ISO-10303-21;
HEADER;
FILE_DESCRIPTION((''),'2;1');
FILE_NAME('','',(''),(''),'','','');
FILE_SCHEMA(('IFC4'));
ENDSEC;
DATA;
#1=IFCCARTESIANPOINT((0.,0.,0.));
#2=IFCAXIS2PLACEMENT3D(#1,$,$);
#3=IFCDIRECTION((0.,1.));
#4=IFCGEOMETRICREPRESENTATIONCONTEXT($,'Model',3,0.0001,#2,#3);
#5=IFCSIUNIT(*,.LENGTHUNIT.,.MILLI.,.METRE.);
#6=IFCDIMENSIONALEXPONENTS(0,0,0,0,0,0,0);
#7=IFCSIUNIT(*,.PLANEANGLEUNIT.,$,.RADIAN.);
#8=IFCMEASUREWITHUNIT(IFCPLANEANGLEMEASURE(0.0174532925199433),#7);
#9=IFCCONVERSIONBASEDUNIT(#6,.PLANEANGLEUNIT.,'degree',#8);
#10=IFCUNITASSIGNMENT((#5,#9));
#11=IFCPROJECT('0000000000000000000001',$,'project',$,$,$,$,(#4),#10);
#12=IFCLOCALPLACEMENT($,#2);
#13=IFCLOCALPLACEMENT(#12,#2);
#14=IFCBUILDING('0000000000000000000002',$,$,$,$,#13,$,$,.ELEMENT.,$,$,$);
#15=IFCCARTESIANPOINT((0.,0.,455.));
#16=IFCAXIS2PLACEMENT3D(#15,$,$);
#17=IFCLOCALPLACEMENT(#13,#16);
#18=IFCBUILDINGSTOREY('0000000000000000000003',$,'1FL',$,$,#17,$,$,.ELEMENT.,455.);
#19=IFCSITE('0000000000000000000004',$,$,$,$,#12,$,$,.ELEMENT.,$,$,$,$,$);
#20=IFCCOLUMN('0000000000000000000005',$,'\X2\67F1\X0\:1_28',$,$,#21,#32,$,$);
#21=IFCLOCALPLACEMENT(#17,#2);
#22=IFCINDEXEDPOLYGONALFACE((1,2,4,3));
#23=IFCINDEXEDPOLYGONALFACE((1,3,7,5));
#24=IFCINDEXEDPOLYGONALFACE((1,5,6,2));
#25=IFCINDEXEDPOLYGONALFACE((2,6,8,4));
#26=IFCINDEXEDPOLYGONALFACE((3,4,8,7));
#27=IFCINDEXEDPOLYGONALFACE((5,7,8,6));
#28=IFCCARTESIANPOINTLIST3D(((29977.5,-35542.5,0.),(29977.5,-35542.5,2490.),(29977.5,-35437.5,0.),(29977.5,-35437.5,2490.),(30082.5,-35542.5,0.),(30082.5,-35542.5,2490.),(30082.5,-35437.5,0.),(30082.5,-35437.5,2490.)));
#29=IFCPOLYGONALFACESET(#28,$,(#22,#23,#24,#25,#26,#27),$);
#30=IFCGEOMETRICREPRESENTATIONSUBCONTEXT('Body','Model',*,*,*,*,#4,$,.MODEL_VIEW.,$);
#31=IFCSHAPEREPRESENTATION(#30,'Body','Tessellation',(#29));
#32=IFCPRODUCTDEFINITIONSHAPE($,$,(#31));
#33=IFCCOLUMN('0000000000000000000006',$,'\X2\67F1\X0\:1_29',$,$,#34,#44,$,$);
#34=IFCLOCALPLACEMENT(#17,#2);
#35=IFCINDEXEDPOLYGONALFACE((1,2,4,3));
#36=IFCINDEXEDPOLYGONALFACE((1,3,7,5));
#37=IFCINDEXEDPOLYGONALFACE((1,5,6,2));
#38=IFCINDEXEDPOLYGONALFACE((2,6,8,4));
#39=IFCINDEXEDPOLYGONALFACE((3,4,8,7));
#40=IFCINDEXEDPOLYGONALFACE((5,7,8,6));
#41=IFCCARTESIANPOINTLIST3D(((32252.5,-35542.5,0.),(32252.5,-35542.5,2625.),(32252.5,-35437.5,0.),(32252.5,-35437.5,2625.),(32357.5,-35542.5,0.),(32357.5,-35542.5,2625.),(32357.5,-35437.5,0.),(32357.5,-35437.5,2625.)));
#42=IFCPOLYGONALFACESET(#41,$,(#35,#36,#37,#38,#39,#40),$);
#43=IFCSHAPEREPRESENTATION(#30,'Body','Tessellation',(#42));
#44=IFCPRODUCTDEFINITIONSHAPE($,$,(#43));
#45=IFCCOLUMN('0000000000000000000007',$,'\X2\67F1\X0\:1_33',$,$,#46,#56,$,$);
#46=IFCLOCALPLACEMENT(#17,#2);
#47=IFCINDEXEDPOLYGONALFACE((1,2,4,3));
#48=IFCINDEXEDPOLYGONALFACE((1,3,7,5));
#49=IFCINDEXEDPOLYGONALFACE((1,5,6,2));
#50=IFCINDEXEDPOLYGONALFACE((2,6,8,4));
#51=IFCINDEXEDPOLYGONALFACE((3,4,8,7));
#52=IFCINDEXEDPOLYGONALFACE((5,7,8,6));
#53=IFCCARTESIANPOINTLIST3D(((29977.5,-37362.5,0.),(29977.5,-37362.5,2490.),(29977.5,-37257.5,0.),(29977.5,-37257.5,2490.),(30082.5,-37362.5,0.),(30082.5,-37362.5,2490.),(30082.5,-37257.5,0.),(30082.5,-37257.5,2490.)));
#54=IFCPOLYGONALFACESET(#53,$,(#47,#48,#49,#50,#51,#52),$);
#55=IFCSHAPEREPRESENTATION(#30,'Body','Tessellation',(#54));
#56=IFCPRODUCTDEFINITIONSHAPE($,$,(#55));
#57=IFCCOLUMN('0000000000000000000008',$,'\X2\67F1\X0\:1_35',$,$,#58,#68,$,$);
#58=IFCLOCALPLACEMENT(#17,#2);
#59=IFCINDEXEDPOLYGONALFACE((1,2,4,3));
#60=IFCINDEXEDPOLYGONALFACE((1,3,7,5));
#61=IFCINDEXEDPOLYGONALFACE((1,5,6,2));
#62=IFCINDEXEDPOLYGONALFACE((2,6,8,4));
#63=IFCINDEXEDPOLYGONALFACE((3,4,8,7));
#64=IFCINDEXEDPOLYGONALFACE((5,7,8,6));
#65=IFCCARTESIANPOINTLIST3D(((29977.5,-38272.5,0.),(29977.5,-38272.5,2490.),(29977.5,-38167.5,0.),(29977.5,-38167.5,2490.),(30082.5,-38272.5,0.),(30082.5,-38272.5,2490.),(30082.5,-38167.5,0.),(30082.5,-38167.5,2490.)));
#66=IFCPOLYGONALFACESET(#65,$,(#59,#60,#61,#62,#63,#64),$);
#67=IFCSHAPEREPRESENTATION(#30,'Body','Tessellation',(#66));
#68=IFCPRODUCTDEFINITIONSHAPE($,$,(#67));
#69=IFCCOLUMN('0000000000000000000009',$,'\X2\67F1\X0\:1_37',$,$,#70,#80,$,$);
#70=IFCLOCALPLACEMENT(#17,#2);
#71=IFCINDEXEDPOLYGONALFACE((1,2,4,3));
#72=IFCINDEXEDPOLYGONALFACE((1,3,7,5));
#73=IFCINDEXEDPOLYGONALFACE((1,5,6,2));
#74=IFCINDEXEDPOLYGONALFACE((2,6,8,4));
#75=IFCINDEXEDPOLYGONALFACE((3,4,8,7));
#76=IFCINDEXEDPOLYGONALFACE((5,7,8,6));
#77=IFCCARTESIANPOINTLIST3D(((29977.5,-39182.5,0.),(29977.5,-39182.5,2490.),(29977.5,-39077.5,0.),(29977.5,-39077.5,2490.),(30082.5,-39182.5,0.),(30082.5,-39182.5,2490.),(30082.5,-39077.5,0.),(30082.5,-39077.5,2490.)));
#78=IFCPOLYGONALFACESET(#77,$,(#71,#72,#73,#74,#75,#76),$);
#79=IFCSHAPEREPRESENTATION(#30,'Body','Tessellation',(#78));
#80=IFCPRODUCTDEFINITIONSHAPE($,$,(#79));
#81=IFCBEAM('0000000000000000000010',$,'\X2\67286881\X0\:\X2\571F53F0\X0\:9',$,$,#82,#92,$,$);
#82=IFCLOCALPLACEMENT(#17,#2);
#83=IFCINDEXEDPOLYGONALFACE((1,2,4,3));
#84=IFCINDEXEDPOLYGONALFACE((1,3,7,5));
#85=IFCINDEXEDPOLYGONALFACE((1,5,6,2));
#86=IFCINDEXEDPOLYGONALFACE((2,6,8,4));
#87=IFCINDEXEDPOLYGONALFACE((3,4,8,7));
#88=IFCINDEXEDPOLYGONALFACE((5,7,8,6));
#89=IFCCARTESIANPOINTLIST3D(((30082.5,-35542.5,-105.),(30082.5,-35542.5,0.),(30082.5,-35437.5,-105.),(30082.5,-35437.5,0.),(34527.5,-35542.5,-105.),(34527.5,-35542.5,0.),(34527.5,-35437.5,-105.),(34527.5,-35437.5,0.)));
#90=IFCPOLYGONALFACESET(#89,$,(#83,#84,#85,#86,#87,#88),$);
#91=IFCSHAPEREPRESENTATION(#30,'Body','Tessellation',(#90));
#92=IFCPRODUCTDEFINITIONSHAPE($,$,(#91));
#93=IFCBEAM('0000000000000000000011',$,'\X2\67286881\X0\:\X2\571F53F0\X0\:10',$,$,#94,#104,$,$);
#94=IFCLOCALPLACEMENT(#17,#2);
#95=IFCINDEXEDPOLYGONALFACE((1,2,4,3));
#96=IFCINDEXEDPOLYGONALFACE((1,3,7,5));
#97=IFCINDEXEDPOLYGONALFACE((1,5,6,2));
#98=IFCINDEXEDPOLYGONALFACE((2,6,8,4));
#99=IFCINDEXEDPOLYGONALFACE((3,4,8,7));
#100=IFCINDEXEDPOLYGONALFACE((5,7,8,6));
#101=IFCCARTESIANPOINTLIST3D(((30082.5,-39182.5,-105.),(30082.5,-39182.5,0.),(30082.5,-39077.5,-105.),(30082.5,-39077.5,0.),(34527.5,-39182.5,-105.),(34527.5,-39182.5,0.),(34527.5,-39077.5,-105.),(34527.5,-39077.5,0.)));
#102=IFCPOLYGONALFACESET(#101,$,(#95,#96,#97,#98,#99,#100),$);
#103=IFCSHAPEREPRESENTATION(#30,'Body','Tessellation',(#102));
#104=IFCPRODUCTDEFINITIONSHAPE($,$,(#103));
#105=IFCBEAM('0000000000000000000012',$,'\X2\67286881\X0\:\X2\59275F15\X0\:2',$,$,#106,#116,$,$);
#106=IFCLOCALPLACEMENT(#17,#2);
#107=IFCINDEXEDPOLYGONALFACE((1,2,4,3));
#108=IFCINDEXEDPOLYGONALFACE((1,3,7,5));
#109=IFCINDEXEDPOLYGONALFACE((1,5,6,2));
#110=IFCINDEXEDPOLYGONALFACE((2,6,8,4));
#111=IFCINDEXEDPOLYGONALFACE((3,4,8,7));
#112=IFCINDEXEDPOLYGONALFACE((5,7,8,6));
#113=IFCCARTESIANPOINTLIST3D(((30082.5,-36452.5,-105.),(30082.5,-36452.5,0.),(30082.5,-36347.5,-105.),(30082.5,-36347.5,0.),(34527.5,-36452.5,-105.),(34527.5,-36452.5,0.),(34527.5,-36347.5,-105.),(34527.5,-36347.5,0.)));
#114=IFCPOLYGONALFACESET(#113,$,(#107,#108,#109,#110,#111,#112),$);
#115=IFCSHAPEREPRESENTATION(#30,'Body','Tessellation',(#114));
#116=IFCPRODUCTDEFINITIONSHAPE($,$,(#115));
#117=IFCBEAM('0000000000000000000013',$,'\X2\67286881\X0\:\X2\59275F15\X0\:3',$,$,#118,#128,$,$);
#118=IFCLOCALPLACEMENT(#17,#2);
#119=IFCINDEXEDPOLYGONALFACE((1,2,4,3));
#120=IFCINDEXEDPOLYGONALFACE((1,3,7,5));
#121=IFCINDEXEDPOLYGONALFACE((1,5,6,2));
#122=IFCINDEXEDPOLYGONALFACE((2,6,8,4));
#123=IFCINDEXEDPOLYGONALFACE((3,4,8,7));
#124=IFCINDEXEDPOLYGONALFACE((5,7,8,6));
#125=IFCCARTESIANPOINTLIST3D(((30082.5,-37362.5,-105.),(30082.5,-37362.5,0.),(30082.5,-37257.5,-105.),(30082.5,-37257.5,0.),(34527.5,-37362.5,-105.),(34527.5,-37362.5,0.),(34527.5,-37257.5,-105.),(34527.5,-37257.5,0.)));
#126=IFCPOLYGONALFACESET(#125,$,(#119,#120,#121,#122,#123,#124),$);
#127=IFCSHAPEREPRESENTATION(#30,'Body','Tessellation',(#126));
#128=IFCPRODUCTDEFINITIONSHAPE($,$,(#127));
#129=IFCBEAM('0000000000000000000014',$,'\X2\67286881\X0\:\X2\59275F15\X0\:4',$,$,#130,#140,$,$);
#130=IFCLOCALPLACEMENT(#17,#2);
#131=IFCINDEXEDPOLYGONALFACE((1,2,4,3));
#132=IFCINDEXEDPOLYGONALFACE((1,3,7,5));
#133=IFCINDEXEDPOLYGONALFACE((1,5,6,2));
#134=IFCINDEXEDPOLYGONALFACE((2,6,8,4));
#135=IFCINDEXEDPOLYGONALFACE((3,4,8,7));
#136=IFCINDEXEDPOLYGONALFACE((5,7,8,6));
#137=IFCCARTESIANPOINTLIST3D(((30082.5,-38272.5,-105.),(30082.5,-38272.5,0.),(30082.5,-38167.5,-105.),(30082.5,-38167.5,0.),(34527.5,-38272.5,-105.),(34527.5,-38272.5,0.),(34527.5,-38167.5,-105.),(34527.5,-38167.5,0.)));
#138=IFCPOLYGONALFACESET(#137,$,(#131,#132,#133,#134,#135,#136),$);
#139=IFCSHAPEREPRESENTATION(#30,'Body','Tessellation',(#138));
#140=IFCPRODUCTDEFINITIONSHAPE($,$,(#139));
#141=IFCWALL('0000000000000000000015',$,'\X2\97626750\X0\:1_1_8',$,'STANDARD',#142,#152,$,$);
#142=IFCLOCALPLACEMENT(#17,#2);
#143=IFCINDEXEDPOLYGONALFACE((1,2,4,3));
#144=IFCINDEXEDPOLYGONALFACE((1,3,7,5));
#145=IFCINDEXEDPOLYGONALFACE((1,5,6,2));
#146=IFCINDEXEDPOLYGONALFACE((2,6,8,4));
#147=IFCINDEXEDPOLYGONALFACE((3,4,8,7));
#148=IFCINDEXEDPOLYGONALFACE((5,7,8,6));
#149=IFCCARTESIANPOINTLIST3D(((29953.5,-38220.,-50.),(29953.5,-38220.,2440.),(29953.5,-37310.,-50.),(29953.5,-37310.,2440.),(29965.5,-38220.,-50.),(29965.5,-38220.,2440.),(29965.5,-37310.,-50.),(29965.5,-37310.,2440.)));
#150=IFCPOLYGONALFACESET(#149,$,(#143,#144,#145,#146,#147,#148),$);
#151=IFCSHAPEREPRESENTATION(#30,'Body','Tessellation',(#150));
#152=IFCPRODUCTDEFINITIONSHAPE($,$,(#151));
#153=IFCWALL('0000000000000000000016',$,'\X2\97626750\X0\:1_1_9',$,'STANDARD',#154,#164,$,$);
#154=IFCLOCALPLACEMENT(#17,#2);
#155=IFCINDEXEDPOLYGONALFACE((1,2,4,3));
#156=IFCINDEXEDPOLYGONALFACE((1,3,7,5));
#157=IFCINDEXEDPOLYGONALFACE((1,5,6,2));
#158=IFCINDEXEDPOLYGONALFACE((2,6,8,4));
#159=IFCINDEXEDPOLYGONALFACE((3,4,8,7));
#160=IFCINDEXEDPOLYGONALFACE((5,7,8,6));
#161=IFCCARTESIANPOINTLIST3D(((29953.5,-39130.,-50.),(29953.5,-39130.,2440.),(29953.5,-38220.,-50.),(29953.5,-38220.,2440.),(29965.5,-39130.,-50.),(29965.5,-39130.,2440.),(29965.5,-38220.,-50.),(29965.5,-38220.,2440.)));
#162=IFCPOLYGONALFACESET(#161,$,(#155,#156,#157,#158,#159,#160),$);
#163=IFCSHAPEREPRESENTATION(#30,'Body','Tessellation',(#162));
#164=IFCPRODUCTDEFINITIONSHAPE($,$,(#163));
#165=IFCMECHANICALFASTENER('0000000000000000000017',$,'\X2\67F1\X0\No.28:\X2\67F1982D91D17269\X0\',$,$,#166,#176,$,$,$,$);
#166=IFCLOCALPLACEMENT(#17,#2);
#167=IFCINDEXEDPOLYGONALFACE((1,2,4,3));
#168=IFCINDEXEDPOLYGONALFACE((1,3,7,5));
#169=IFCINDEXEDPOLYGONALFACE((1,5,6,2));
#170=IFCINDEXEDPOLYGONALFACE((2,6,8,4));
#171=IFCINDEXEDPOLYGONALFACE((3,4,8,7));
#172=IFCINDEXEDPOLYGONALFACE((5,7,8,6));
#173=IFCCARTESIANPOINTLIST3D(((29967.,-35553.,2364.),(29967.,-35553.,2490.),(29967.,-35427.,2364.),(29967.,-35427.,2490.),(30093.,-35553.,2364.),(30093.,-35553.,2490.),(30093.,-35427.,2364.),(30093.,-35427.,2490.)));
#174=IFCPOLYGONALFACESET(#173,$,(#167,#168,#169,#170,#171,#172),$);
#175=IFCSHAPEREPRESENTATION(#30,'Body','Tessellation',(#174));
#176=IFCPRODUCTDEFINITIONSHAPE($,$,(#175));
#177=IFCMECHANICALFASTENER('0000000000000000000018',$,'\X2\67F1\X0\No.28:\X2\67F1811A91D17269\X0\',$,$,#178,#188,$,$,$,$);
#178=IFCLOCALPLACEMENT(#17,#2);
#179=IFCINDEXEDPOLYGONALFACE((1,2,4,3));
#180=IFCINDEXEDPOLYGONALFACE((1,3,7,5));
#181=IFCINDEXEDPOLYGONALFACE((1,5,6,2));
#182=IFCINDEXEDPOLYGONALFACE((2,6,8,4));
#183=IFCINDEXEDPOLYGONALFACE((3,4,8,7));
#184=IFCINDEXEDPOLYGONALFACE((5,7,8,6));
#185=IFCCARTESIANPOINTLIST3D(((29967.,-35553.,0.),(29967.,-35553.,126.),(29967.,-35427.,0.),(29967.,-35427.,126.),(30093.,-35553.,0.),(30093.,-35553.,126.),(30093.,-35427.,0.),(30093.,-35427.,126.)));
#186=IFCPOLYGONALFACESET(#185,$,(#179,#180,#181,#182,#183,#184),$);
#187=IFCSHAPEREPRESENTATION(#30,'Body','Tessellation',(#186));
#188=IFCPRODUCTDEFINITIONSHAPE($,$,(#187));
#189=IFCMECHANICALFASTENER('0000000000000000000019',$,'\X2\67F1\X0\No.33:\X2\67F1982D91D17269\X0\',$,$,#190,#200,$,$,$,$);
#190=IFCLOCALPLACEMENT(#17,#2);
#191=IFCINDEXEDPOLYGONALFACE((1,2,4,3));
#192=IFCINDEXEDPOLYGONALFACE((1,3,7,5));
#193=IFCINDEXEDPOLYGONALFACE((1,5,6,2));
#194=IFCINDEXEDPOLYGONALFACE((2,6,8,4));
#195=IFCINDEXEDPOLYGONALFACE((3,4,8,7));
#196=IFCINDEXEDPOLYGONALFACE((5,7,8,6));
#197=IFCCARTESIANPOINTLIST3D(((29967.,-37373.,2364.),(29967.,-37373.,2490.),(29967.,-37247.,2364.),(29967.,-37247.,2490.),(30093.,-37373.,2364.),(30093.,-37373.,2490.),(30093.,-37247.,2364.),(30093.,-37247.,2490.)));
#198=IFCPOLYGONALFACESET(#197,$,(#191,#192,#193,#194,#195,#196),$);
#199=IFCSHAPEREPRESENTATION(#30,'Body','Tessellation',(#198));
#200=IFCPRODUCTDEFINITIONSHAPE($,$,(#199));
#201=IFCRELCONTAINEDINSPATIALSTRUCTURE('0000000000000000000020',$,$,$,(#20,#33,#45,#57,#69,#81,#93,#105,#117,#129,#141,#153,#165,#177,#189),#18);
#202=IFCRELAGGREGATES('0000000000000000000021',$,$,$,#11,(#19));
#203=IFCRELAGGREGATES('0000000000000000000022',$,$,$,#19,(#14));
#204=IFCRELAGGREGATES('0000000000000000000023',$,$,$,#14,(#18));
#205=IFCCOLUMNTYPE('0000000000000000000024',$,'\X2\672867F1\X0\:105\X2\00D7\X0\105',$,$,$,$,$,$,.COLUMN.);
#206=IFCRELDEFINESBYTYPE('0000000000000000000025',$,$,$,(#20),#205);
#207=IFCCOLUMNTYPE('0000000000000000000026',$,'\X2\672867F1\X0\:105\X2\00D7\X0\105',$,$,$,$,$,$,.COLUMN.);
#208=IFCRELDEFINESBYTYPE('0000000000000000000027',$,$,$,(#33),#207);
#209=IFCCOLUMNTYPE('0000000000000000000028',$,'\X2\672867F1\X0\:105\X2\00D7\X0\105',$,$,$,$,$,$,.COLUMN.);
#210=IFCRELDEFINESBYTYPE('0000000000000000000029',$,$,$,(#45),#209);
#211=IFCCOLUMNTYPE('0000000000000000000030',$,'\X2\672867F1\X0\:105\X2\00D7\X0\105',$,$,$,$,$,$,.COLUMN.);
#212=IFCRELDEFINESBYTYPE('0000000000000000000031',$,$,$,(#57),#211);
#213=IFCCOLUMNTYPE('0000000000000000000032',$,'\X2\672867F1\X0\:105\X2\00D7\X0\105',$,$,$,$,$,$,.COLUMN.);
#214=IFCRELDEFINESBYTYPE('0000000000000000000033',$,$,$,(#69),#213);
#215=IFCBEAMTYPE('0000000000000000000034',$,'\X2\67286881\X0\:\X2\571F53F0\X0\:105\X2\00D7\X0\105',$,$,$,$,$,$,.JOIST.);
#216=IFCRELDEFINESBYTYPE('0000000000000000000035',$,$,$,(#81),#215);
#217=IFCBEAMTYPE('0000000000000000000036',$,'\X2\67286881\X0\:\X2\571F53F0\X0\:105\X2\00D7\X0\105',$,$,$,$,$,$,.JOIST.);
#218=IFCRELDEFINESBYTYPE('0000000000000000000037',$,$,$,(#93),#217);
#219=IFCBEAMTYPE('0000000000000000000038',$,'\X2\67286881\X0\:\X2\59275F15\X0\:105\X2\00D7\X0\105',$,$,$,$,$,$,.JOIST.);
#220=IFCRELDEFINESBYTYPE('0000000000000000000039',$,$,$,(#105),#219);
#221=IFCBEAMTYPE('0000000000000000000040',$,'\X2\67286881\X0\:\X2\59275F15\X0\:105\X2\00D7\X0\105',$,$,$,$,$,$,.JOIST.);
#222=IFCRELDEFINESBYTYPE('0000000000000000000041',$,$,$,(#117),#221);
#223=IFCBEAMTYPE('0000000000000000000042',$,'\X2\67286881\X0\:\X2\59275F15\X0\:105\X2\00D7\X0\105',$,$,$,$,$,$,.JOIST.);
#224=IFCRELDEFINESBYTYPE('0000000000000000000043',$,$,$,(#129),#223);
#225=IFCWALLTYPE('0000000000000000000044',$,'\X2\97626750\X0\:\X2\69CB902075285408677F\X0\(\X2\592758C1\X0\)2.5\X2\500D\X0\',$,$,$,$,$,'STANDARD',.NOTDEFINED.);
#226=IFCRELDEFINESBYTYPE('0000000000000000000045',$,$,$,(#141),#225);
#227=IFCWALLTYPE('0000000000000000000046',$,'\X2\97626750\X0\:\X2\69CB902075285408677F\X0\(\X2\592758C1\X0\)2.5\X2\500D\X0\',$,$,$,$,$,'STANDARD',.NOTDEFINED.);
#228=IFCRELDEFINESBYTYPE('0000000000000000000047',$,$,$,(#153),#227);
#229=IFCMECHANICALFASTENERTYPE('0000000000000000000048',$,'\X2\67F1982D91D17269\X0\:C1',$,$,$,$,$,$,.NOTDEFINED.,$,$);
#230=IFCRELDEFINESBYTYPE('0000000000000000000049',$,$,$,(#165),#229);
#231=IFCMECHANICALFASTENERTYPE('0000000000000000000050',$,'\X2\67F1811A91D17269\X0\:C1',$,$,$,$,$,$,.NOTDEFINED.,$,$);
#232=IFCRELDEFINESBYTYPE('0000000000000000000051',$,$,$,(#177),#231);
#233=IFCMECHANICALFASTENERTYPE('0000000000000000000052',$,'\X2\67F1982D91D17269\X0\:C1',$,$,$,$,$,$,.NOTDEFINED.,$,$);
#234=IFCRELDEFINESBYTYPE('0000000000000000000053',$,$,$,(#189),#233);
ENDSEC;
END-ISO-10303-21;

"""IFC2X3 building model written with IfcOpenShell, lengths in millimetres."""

from ifc_helpers import new_model, entity, si_unit, converted_unit, direction, frame, origin, origin_with_axes, origin_2d, place, context, subcontext, project, spatial, polyline, rectangle, outline, extrude, type_object, element, save


model = new_model("IFC2X3")

# Units and contexts
model_context = context("Model", 3, precision=0.0001, world=origin(), true_north=direction((0.0, 1.0)))
body_context = subcontext(model_context, "Body", "Model", "MODEL_VIEW")
ifc_project = project(units=[si_unit("LENGTHUNIT", "METRE", prefix="MILLI"), converted_unit("PLANEANGLEUNIT", "degree", entity("IfcPlaneAngleMeasure", 0.0174532925199433), si_unit("PLANEANGLEUNIT", "RADIAN"), dimensions=[0, 0, 0, 0, 0, 0, 0])], contexts=[model_context])

# Site, building, storey
site_placement = place(None, origin())
site = spatial("IfcSite", under=ifc_project, at=site_placement, CompositionType="ELEMENT")
building_placement = place(site_placement, origin())
building = spatial("IfcBuilding", under=site, at=building_placement, CompositionType="ELEMENT")
storey_placement = place(building_placement, frame((0.0, 0.0, 455.0)))
storey = spatial("IfcBuildingStorey", under=building, at=storey_placement, Name="1FL", CompositionType="ELEMENT", Elevation=455.0)

# Columns
column_type_1 = type_object("IfcColumnType", Name="木柱:105×105", PredefinedType="COLUMN")
column_1_placement = place(storey_placement, frame((30030.0, -35490.0, 0.0)))
element("IfcColumn", 1, at=column_1_placement, inside=storey, type_object=column_type_1, Name="柱:1_28", context=body_context, shape_type="SweptSolid", body=[
    extrude(rectangle(XDim=105.0, YDim=105.0, at=origin_2d()), origin_with_axes(), (0.0, 0.0, 1.0), 2490.0),
])
column_type_2 = type_object("IfcColumnType", Name="木柱:105×105", PredefinedType="COLUMN")
column_2_placement = place(storey_placement, frame((32305.0, -35490.0, 0.0)))
element("IfcColumn", 2, at=column_2_placement, inside=storey, type_object=column_type_2, Name="柱:1_29", context=body_context, shape_type="SweptSolid", body=[
    extrude(rectangle(XDim=105.0, YDim=105.0, at=origin_2d()), origin_with_axes(), (0.0, 0.0, 1.0), 2625.0),
])
column_type_3 = type_object("IfcColumnType", Name="木柱:105×105", PredefinedType="COLUMN")
column_3_placement = place(storey_placement, frame((30030.0, -37310.0, 0.0)))
element("IfcColumn", 3, at=column_3_placement, inside=storey, type_object=column_type_3, Name="柱:1_33", context=body_context, shape_type="SweptSolid", body=[
    extrude(rectangle(XDim=105.0, YDim=105.0, at=origin_2d()), origin_with_axes(), (0.0, 0.0, 1.0), 2490.0),
])
column_type_4 = type_object("IfcColumnType", Name="木柱:105×105", PredefinedType="COLUMN")
column_4_placement = place(storey_placement, frame((30030.0, -38220.0, 0.0)))
element("IfcColumn", 4, at=column_4_placement, inside=storey, type_object=column_type_4, Name="柱:1_35", context=body_context, shape_type="SweptSolid", body=[
    extrude(rectangle(XDim=105.0, YDim=105.0, at=origin_2d()), origin_with_axes(), (0.0, 0.0, 1.0), 2490.0),
])
column_type_5 = type_object("IfcColumnType", Name="木柱:105×105", PredefinedType="COLUMN")
column_5_placement = place(storey_placement, frame((30030.0, -39130.0, 0.0)))
element("IfcColumn", 5, at=column_5_placement, inside=storey, type_object=column_type_5, Name="柱:1_37", context=body_context, shape_type="SweptSolid", body=[
    extrude(rectangle(XDim=105.0, YDim=105.0, at=origin_2d()), origin_with_axes(), (0.0, 0.0, 1.0), 2490.0),
])

# Beams
beam_type_1 = type_object("IfcBeamType", Name="木梁:土台:105×105", PredefinedType="JOIST")
beam_1_placement = place(storey_placement, frame((30082.5, -35490.0, -52.5), z_axis=(1.0, 0.0, 0.0), x_axis=(0.0, 1.0, 0.0)))
element("IfcBeam", 6, at=beam_1_placement, inside=storey, type_object=beam_type_1, Name="木梁:土台:9", context=body_context, shape_type="SweptSolid", body=[
    extrude(rectangle(XDim=105.0, YDim=105.0, at=origin_2d()), origin_with_axes(), (0.0, 0.0, 1.0), 4445.0),
])
beam_type_2 = type_object("IfcBeamType", Name="木梁:土台:105×105", PredefinedType="JOIST")
beam_2_placement = place(storey_placement, frame((30082.5, -39130.0, -52.5), z_axis=(1.0, 0.0, 0.0), x_axis=(0.0, 1.0, 0.0)))
element("IfcBeam", 7, at=beam_2_placement, inside=storey, type_object=beam_type_2, Name="木梁:土台:10", context=body_context, shape_type="SweptSolid", body=[
    extrude(rectangle(XDim=105.0, YDim=105.0, at=origin_2d()), origin_with_axes(), (0.0, 0.0, 1.0), 4445.0),
])
beam_type_3 = type_object("IfcBeamType", Name="木梁:大引:105×105", PredefinedType="JOIST")
beam_3_placement = place(storey_placement, frame((30082.5, -36400.0, -52.5), z_axis=(1.0, 0.0, 0.0), x_axis=(0.0, 1.0, 0.0)))
element("IfcBeam", 8, at=beam_3_placement, inside=storey, type_object=beam_type_3, Name="木梁:大引:2", context=body_context, shape_type="SweptSolid", body=[
    extrude(rectangle(XDim=105.0, YDim=105.0, at=origin_2d()), origin_with_axes(), (0.0, 0.0, 1.0), 4445.0),
])
beam_type_4 = type_object("IfcBeamType", Name="木梁:大引:105×105", PredefinedType="JOIST")
beam_4_placement = place(storey_placement, frame((30082.5, -37310.0, -52.5), z_axis=(1.0, 0.0, 0.0), x_axis=(0.0, 1.0, 0.0)))
element("IfcBeam", 9, at=beam_4_placement, inside=storey, type_object=beam_type_4, Name="木梁:大引:3", context=body_context, shape_type="SweptSolid", body=[
    extrude(rectangle(XDim=105.0, YDim=105.0, at=origin_2d()), origin_with_axes(), (0.0, 0.0, 1.0), 4445.0),
])
beam_type_5 = type_object("IfcBeamType", Name="木梁:大引:105×105", PredefinedType="JOIST")
beam_5_placement = place(storey_placement, frame((30082.5, -38220.0, -52.5), z_axis=(1.0, 0.0, 0.0), x_axis=(0.0, 1.0, 0.0)))
element("IfcBeam", 10, at=beam_5_placement, inside=storey, type_object=beam_type_5, Name="木梁:大引:4", context=body_context, shape_type="SweptSolid", body=[
    extrude(rectangle(XDim=105.0, YDim=105.0, at=origin_2d()), origin_with_axes(), (0.0, 0.0, 1.0), 4445.0),
])

# Walls
wall_type_1 = type_object("IfcWallType", Name="面材:構造用合板(大壁)2.5倍", ElementType="STANDARD", PredefinedType="NOTDEFINED")
wall_1_placement = place(storey_placement, frame((29965.5, -37765.0, -50.0), z_axis=(-1.0, 0.0, 0.0), x_axis=(0.0, -1.0, 0.0)))
element("IfcWall", 11, at=wall_1_placement, inside=storey, type_object=wall_type_1, Name="面材:1_1_8", ObjectType="STANDARD", context=body_context, shape_type="SweptSolid", body=[
    extrude(outline(polyline([(455.0, 0.0, 0.0), (-455.0, 0.0, 0.0), (-455.0, 2490.0, 0.0), (455.0, 2490.0, 0.0), (455.0, 0.0, 0.0)])), origin_with_axes(), (0.0, 0.0, 1.0), 12.0),
])
wall_type_2 = type_object("IfcWallType", Name="面材:構造用合板(大壁)2.5倍", ElementType="STANDARD", PredefinedType="NOTDEFINED")
wall_2_placement = place(storey_placement, frame((29965.5, -38675.0, -50.0), z_axis=(-1.0, 0.0, 0.0), x_axis=(0.0, -1.0, 0.0)))
element("IfcWall", 12, at=wall_2_placement, inside=storey, type_object=wall_type_2, Name="面材:1_1_9", ObjectType="STANDARD", context=body_context, shape_type="SweptSolid", body=[
    extrude(outline(polyline([(455.0, 0.0, 0.0), (-455.0, 0.0, 0.0), (-455.0, 2490.0, 0.0), (455.0, 2490.0, 0.0), (455.0, 0.0, 0.0)])), origin_with_axes(), (0.0, 0.0, 1.0), 12.0),
])

# Mechanical fasteners
mechanical_fastener_type_1 = type_object("IfcMechanicalFastenerType", Name="柱頭金物:C1")
mechanical_fastener_1_placement = place(storey_placement, frame((30030.0, -35490.0, 2364.0)))
element("IfcMechanicalFastener", 13, at=mechanical_fastener_1_placement, inside=storey, type_object=mechanical_fastener_type_1, Name="柱No.28:柱頭金物", context=body_context, shape_type="SweptSolid", body=[
    extrude(rectangle(XDim=126.0, YDim=126.0, at=origin_2d()), origin_with_axes(), (0.0, 0.0, 1.0), 126.0),
])
mechanical_fastener_type_2 = type_object("IfcMechanicalFastenerType", Name="柱脚金物:C1")
mechanical_fastener_2_placement = place(storey_placement, frame((30030.0, -35490.0, 0.0)))
element("IfcMechanicalFastener", 14, at=mechanical_fastener_2_placement, inside=storey, type_object=mechanical_fastener_type_2, Name="柱No.28:柱脚金物", context=body_context, shape_type="SweptSolid", body=[
    extrude(rectangle(XDim=126.0, YDim=126.0, at=origin_2d()), origin_with_axes(), (0.0, 0.0, 1.0), 126.0),
])
mechanical_fastener_type_3 = type_object("IfcMechanicalFastenerType", Name="柱頭金物:C1")
mechanical_fastener_3_placement = place(storey_placement, frame((30030.0, -37310.0, 2364.0)))
element("IfcMechanicalFastener", 15, at=mechanical_fastener_3_placement, inside=storey, type_object=mechanical_fastener_type_3, Name="柱No.33:柱頭金物", context=body_context, shape_type="SweptSolid", body=[
    extrude(rectangle(XDim=126.0, YDim=126.0, at=origin_2d()), origin_with_axes(), (0.0, 0.0, 1.0), 126.0),
])

save(model, "model.ifc")
